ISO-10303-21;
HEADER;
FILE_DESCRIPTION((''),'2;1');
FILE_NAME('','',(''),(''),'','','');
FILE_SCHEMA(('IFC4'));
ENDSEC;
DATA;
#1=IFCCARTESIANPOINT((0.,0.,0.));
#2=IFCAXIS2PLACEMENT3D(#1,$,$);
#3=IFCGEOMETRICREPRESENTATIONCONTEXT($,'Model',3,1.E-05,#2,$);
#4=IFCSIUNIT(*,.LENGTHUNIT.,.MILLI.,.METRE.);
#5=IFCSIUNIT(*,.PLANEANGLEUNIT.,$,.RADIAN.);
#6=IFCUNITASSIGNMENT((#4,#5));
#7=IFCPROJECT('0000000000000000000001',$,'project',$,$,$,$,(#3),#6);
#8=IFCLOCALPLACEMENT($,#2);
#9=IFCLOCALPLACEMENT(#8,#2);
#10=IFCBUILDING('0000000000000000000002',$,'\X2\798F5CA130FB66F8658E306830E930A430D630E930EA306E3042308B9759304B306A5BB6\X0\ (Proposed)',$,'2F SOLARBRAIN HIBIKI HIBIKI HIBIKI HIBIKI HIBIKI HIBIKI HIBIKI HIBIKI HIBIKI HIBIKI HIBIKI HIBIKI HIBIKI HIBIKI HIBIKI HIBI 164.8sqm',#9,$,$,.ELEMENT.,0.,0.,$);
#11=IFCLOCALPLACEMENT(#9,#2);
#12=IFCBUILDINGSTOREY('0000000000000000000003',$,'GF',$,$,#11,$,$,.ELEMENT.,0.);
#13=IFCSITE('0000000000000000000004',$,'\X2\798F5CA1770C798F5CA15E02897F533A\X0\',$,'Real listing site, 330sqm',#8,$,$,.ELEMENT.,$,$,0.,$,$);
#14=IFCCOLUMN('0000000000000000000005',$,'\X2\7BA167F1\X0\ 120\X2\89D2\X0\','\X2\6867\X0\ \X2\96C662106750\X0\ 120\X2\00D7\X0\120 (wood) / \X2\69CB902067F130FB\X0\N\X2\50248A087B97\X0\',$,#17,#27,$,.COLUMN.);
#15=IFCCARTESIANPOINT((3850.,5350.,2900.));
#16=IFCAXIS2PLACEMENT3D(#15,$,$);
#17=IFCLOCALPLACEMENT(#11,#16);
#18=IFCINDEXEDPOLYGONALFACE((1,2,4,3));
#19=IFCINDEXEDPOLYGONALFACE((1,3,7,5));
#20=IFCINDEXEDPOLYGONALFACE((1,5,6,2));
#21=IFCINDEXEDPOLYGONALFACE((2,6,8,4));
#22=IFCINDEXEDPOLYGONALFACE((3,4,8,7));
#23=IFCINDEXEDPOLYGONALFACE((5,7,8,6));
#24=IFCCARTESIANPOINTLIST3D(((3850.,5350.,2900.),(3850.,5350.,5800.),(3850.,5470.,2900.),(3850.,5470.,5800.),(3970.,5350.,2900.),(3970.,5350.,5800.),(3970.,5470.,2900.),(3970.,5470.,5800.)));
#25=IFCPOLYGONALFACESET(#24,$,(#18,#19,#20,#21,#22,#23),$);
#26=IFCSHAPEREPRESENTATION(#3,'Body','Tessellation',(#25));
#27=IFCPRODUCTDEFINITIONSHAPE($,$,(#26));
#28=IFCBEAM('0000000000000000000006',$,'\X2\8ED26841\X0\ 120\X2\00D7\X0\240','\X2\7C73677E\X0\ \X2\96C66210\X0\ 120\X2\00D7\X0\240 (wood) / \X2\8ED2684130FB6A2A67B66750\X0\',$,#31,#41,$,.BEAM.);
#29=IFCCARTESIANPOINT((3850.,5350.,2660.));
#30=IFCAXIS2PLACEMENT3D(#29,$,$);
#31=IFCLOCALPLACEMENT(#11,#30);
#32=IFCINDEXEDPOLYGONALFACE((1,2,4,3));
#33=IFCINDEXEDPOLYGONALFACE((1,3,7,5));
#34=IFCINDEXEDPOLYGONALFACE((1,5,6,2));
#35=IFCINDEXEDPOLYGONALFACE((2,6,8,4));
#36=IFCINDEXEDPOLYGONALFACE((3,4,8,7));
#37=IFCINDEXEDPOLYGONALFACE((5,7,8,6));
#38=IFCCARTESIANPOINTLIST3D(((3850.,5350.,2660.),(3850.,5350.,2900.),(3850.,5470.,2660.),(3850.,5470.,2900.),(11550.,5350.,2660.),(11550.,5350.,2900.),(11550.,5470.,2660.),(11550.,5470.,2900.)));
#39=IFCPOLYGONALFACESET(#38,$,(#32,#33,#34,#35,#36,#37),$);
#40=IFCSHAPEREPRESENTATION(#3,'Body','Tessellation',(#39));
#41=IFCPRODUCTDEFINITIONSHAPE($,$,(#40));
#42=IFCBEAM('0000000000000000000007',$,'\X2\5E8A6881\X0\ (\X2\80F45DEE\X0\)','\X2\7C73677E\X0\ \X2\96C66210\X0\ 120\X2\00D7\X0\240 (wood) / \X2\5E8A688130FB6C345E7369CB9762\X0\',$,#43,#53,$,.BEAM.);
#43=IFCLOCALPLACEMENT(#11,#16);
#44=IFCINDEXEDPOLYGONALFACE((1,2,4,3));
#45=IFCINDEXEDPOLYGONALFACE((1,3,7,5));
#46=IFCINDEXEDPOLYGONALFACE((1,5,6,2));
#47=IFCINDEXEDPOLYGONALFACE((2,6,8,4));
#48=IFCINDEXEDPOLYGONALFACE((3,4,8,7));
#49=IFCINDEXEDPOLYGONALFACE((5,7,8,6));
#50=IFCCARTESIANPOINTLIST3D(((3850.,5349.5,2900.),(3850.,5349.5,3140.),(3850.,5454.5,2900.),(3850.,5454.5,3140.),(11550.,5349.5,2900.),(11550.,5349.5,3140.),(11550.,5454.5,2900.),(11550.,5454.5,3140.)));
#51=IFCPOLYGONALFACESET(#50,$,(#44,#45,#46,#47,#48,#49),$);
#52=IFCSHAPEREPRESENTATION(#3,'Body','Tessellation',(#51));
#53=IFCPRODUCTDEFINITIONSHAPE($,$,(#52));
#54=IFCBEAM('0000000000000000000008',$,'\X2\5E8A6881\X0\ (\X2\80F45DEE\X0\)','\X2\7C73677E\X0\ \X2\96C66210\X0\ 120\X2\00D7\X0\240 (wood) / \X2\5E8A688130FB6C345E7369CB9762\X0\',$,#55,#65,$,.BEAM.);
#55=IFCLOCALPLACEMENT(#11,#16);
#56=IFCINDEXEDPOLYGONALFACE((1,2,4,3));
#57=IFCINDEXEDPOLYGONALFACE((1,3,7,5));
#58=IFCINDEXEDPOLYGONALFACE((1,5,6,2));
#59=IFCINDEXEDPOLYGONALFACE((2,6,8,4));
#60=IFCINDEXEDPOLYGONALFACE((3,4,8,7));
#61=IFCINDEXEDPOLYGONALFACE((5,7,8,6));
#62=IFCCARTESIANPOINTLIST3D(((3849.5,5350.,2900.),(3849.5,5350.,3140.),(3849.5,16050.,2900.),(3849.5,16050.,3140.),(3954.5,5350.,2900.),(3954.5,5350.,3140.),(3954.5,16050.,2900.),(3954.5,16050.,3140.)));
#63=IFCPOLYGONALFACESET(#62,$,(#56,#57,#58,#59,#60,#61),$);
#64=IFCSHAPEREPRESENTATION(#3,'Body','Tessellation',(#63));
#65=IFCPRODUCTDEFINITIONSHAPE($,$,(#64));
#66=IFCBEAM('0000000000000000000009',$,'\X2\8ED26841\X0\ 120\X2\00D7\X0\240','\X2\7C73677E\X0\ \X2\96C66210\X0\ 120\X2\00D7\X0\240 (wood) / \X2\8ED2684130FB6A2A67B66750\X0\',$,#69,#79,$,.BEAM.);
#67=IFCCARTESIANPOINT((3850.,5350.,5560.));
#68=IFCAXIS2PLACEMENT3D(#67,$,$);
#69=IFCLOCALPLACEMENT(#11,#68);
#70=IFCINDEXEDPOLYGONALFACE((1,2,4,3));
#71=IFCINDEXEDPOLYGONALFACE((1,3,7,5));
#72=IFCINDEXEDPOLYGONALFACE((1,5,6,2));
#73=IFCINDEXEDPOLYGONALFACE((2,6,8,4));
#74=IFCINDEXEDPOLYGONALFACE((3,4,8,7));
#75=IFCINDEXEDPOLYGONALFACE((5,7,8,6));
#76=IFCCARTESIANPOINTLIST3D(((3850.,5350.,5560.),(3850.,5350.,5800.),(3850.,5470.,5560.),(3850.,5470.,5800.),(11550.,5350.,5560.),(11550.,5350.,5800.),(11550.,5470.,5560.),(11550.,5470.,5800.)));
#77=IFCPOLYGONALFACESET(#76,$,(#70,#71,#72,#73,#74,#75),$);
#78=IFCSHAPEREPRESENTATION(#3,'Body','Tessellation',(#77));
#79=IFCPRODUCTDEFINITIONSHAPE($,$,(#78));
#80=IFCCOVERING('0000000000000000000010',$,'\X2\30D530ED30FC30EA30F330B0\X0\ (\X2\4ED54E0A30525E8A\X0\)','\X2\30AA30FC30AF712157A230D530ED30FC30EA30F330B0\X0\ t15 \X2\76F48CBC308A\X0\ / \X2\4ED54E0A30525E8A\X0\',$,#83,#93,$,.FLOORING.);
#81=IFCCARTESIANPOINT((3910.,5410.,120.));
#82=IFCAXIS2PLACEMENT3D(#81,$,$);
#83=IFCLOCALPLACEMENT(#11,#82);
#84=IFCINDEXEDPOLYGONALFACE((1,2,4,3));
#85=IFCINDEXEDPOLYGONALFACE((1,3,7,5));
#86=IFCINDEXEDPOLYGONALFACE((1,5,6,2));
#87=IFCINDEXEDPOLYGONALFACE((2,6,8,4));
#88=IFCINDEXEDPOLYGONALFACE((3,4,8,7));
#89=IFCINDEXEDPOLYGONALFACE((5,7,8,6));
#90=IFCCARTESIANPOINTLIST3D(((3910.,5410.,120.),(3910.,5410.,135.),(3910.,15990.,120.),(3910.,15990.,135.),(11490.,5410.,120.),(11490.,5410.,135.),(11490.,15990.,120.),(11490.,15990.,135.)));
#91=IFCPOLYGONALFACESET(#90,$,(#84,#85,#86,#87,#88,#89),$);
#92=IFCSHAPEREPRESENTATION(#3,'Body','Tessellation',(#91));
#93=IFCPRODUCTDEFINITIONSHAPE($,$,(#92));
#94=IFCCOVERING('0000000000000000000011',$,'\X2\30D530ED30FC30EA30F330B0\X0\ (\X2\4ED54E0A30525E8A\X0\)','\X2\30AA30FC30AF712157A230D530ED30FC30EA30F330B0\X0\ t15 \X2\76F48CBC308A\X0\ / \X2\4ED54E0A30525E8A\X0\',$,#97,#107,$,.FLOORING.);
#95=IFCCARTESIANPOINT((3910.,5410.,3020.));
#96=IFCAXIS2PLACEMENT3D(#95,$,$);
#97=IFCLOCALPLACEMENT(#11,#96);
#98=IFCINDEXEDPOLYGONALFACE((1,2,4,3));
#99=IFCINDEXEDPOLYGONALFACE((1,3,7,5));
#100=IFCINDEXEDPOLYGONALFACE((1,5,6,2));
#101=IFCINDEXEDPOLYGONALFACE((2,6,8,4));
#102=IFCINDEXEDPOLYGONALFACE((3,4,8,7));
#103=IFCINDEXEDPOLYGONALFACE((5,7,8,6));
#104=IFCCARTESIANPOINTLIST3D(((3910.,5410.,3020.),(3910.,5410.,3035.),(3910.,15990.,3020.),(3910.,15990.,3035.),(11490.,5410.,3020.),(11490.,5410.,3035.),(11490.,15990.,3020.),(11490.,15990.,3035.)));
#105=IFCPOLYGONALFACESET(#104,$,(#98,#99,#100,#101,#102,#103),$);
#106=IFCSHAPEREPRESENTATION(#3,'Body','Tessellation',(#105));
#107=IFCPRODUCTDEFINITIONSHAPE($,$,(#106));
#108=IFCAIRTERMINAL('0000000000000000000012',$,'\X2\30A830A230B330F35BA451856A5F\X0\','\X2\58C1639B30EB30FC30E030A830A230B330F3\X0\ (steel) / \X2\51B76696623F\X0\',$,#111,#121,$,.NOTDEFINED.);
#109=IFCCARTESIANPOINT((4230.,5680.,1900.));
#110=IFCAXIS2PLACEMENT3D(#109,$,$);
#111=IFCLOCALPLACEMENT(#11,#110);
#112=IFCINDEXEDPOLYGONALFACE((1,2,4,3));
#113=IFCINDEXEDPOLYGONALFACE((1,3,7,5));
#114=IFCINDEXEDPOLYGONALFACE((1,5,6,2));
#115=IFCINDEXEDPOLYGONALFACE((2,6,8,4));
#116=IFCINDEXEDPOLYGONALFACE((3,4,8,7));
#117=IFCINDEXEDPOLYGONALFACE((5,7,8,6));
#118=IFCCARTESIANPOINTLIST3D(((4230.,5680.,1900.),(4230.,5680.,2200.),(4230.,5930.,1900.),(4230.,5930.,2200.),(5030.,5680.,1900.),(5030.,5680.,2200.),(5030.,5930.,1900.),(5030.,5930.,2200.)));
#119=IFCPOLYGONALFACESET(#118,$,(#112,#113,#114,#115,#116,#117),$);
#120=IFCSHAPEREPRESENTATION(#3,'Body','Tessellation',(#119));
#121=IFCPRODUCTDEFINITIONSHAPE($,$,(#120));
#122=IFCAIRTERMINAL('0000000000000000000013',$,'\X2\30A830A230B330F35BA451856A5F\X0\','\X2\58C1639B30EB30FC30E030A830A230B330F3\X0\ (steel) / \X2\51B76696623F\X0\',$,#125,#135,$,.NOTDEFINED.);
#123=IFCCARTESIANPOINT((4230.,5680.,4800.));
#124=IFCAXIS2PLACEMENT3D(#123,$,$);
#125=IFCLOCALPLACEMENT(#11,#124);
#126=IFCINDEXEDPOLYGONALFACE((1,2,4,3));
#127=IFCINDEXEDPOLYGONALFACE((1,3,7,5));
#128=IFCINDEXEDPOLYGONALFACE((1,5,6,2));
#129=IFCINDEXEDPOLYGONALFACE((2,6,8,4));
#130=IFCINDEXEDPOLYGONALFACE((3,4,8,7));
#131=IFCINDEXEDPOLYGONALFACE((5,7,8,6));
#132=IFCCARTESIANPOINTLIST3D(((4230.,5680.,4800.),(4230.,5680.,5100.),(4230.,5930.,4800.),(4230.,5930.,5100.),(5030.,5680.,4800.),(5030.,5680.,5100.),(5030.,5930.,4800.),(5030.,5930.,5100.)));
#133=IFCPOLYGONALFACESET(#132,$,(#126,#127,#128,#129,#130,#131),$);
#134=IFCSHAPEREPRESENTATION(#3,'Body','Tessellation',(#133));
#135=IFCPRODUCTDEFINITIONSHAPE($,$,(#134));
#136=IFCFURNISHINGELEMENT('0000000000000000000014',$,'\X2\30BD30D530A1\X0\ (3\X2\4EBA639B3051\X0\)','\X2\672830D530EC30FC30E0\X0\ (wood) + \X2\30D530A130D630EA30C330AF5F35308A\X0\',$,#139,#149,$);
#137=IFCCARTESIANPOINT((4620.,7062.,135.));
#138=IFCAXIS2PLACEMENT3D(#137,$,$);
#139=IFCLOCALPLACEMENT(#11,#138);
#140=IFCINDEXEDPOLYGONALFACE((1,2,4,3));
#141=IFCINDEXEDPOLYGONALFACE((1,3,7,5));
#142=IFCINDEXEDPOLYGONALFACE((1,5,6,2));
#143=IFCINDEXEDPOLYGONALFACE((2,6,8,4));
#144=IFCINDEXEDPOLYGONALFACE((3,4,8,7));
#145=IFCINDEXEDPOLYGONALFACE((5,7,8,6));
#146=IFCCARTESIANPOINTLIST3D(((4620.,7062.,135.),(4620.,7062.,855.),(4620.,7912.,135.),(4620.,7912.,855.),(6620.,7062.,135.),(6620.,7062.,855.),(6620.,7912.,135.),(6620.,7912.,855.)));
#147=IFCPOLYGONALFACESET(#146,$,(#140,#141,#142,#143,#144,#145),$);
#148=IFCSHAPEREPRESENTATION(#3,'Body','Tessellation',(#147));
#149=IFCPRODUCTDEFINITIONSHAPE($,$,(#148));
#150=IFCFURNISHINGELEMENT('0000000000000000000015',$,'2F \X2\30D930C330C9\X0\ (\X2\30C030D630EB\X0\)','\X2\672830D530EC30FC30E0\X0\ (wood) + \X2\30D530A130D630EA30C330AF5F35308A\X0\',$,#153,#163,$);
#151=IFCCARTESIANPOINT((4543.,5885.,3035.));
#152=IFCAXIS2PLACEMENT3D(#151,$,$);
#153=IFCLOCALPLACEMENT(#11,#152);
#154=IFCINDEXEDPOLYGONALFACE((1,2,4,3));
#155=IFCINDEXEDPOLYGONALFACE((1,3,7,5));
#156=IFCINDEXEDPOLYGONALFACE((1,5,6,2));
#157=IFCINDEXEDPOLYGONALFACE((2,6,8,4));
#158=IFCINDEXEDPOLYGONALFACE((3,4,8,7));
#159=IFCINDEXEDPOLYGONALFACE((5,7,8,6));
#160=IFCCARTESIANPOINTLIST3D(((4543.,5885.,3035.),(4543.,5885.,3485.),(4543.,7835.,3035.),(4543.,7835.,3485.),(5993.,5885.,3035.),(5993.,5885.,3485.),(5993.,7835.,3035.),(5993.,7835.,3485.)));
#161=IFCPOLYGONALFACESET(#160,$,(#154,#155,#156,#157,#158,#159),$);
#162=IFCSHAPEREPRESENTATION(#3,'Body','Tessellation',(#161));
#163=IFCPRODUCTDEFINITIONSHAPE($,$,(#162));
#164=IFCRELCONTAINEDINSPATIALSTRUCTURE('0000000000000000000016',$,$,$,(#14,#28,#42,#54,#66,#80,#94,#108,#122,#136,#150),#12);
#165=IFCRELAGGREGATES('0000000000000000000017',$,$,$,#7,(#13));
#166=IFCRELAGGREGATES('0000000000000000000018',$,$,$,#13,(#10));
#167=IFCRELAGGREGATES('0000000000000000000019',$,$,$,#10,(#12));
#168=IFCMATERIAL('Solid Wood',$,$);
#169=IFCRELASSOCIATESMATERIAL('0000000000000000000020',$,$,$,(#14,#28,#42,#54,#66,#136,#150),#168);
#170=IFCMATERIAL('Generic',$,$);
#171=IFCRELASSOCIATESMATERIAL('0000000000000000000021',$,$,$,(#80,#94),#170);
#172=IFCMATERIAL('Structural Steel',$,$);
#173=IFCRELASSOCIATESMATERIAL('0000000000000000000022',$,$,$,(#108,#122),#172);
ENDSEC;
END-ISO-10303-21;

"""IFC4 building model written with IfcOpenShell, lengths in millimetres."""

from ifc_helpers import new_model, si_unit, frame, frame_2d, origin, place, context, project, spatial, rectangle, extrude, material, element, save


model = new_model("IFC4")

# Units and contexts
model_context = context("Model", 3, precision=1e-05, world=origin())
ifc_project = project(units=[si_unit("LENGTHUNIT", "METRE", prefix="MILLI"), si_unit("PLANEANGLEUNIT", "RADIAN")], contexts=[model_context])

# Site, building, storey
site_placement = place(None, origin())
site = spatial("IfcSite", under=ifc_project, at=site_placement, Name="福岡県福岡市西区", ObjectType="Real listing site, 330sqm", CompositionType="ELEMENT", RefElevation=0.0)
building_placement = place(site_placement, origin())
building = spatial("IfcBuilding", under=site, at=building_placement, Name="福岡・書斎とライブラリのある静かな家 (Proposed)", ObjectType="2F SOLARBRAIN HIBIKI HIBIKI HIBIKI HIBIKI HIBIKI HIBIKI HIBIKI HIBIKI HIBIKI HIBIKI HIBIKI HIBIKI HIBIKI HIBIKI HIBIKI HIBI 164.8sqm", CompositionType="ELEMENT", ElevationOfRefHeight=0.0, ElevationOfTerrain=0.0)
storey_placement = place(building_placement, origin())
storey = spatial("IfcBuildingStorey", under=building, at=storey_placement, Name="GF", CompositionType="ELEMENT", Elevation=0.0)

# Column
ifc_material_1 = material(Name="Solid Wood")
column_1_placement = place(storey_placement, frame((3850.0, 5350.0, 2900.0)))
element("IfcColumn", 1, at=column_1_placement, inside=storey, material=ifc_material_1, Name="管柱 120角", Description="桧 集成材 120×120 (wood) / 構造柱・N値計算", PredefinedType="COLUMN", context=model_context, shape_type="SweptSolid", body=[
    extrude(rectangle(XDim=120.0, YDim=120.0, at=frame_2d((60.0, 60.0))), frame((3850.0, 5350.0, 2900.0)), (0.0, 0.0, 1.0), 2900.0),
])

# Beams
beam_1_placement = place(storey_placement, frame((3850.0, 5350.0, 2660.0)))
element("IfcBeam", 2, at=beam_1_placement, inside=storey, material=ifc_material_1, Name="軒桁 120×240", Description="米松 集成 120×240 (wood) / 軒桁・横架材", PredefinedType="BEAM", context=model_context, shape_type="SweptSolid", body=[
    extrude(rectangle(XDim=7700.0, YDim=120.0, at=frame_2d((3850.0, 60.0))), frame((3850.0, 5350.0, 2660.0)), (0.0, 0.0, 1.0), 240.0),
])
beam_2_placement = place(storey_placement, frame((3850.0, 5350.0, 2900.0)))
element("IfcBeam", 3, at=beam_2_placement, inside=storey, material=ifc_material_1, Name="床梁 (胴差)", Description="米松 集成 120×240 (wood) / 床梁・水平構面", PredefinedType="BEAM", context=model_context, shape_type="SweptSolid", body=[
    extrude(rectangle(XDim=7700.0, YDim=105.0, at=frame_2d((3850.0, 52.0))), frame((3850.0, 5350.0, 2900.0)), (0.0, 0.0, 1.0), 240.0),
])
beam_3_placement = place(storey_placement, frame((3850.0, 5350.0, 2900.0)))
element("IfcBeam", 4, at=beam_3_placement, inside=storey, material=ifc_material_1, Name="床梁 (胴差)", Description="米松 集成 120×240 (wood) / 床梁・水平構面", PredefinedType="BEAM", context=model_context, shape_type="SweptSolid", body=[
    extrude(rectangle(XDim=105.0, YDim=10700.0, at=frame_2d((52.0, 5350.0))), frame((3850.0, 5350.0, 2900.0)), (0.0, 0.0, 1.0), 240.0),
])
beam_4_placement = place(storey_placement, frame((3850.0, 5350.0, 5560.0)))
element("IfcBeam", 5, at=beam_4_placement, inside=storey, material=ifc_material_1, Name="軒桁 120×240", Description="米松 集成 120×240 (wood) / 軒桁・横架材", PredefinedType="BEAM", context=model_context, shape_type="SweptSolid", body=[
    extrude(rectangle(XDim=7700.0, YDim=120.0, at=frame_2d((3850.0, 60.0))), frame((3850.0, 5350.0, 5560.0)), (0.0, 0.0, 1.0), 240.0),
])

# Coverings
ifc_material_2 = material(Name="Generic")
covering_1_placement = place(storey_placement, frame((3910.0, 5410.0, 120.0)))
element("IfcCovering", 6, at=covering_1_placement, inside=storey, material=ifc_material_2, Name="フローリング (仕上げ床)", Description="オーク無垢フローリング t15 直貼り / 仕上げ床", PredefinedType="FLOORING", context=model_context, shape_type="SweptSolid", body=[
    extrude(rectangle(XDim=7580.0, YDim=10580.0, at=frame_2d((3790.0, 5290.0))), frame((3910.0, 5410.0, 120.0)), (0.0, 0.0, 1.0), 15.0),
])
covering_2_placement = place(storey_placement, frame((3910.0, 5410.0, 3020.0)))
element("IfcCovering", 7, at=covering_2_placement, inside=storey, material=ifc_material_2, Name="フローリング (仕上げ床)", Description="オーク無垢フローリング t15 直貼り / 仕上げ床", PredefinedType="FLOORING", context=model_context, shape_type="SweptSolid", body=[
    extrude(rectangle(XDim=7580.0, YDim=10580.0, at=frame_2d((3790.0, 5290.0))), frame((3910.0, 5410.0, 3020.0)), (0.0, 0.0, 1.0), 15.0),
])

# Air terminals
ifc_material_3 = material(Name="Structural Steel")
air_terminal_1_placement = place(storey_placement, frame((4230.0, 5680.0, 1900.0)))
element("IfcAirTerminal", 8, at=air_terminal_1_placement, inside=storey, material=ifc_material_3, Name="エアコン室内機", Description="壁掛ルームエアコン (steel) / 冷暖房", PredefinedType="NOTDEFINED", context=model_context, shape_type="SweptSolid", body=[
    extrude(rectangle(XDim=800.0, YDim=250.0, at=frame_2d((400.0, 125.0))), frame((4230.0, 5680.0, 1900.0)), (0.0, 0.0, 1.0), 300.0),
])
air_terminal_2_placement = place(storey_placement, frame((4230.0, 5680.0, 4800.0)))
element("IfcAirTerminal", 9, at=air_terminal_2_placement, inside=storey, material=ifc_material_3, Name="エアコン室内機", Description="壁掛ルームエアコン (steel) / 冷暖房", PredefinedType="NOTDEFINED", context=model_context, shape_type="SweptSolid", body=[
    extrude(rectangle(XDim=800.0, YDim=250.0, at=frame_2d((400.0, 125.0))), frame((4230.0, 5680.0, 4800.0)), (0.0, 0.0, 1.0), 300.0),
])

# Furnishing elements
furnishing_1_placement = place(storey_placement, frame((4620.0, 7062.0, 135.0)))
element("IfcFurnishingElement", 10, at=furnishing_1_placement, inside=storey, material=ifc_material_1, Name="ソファ (3人掛け)", Description="木フレーム (wood) + ファブリック張り", context=model_context, shape_type="SweptSolid", body=[
    extrude(rectangle(XDim=2000.0, YDim=850.0, at=frame_2d((1000.0, 425.0))), frame((4620.0, 7062.0, 135.0)), (0.0, 0.0, 1.0), 720.0),
])
furnishing_2_placement = place(storey_placement, frame((4543.0, 5885.0, 3035.0)))
element("IfcFurnishingElement", 11, at=furnishing_2_placement, inside=storey, material=ifc_material_1, Name="2F ベッド (ダブル)", Description="木フレーム (wood) + ファブリック張り", context=model_context, shape_type="SweptSolid", body=[
    extrude(rectangle(XDim=1450.0, YDim=1950.0, at=frame_2d((725.0, 975.0))), frame((4543.0, 5885.0, 3035.0)), (0.0, 0.0, 1.0), 450.0),
])

save(model, "model.ifc")
